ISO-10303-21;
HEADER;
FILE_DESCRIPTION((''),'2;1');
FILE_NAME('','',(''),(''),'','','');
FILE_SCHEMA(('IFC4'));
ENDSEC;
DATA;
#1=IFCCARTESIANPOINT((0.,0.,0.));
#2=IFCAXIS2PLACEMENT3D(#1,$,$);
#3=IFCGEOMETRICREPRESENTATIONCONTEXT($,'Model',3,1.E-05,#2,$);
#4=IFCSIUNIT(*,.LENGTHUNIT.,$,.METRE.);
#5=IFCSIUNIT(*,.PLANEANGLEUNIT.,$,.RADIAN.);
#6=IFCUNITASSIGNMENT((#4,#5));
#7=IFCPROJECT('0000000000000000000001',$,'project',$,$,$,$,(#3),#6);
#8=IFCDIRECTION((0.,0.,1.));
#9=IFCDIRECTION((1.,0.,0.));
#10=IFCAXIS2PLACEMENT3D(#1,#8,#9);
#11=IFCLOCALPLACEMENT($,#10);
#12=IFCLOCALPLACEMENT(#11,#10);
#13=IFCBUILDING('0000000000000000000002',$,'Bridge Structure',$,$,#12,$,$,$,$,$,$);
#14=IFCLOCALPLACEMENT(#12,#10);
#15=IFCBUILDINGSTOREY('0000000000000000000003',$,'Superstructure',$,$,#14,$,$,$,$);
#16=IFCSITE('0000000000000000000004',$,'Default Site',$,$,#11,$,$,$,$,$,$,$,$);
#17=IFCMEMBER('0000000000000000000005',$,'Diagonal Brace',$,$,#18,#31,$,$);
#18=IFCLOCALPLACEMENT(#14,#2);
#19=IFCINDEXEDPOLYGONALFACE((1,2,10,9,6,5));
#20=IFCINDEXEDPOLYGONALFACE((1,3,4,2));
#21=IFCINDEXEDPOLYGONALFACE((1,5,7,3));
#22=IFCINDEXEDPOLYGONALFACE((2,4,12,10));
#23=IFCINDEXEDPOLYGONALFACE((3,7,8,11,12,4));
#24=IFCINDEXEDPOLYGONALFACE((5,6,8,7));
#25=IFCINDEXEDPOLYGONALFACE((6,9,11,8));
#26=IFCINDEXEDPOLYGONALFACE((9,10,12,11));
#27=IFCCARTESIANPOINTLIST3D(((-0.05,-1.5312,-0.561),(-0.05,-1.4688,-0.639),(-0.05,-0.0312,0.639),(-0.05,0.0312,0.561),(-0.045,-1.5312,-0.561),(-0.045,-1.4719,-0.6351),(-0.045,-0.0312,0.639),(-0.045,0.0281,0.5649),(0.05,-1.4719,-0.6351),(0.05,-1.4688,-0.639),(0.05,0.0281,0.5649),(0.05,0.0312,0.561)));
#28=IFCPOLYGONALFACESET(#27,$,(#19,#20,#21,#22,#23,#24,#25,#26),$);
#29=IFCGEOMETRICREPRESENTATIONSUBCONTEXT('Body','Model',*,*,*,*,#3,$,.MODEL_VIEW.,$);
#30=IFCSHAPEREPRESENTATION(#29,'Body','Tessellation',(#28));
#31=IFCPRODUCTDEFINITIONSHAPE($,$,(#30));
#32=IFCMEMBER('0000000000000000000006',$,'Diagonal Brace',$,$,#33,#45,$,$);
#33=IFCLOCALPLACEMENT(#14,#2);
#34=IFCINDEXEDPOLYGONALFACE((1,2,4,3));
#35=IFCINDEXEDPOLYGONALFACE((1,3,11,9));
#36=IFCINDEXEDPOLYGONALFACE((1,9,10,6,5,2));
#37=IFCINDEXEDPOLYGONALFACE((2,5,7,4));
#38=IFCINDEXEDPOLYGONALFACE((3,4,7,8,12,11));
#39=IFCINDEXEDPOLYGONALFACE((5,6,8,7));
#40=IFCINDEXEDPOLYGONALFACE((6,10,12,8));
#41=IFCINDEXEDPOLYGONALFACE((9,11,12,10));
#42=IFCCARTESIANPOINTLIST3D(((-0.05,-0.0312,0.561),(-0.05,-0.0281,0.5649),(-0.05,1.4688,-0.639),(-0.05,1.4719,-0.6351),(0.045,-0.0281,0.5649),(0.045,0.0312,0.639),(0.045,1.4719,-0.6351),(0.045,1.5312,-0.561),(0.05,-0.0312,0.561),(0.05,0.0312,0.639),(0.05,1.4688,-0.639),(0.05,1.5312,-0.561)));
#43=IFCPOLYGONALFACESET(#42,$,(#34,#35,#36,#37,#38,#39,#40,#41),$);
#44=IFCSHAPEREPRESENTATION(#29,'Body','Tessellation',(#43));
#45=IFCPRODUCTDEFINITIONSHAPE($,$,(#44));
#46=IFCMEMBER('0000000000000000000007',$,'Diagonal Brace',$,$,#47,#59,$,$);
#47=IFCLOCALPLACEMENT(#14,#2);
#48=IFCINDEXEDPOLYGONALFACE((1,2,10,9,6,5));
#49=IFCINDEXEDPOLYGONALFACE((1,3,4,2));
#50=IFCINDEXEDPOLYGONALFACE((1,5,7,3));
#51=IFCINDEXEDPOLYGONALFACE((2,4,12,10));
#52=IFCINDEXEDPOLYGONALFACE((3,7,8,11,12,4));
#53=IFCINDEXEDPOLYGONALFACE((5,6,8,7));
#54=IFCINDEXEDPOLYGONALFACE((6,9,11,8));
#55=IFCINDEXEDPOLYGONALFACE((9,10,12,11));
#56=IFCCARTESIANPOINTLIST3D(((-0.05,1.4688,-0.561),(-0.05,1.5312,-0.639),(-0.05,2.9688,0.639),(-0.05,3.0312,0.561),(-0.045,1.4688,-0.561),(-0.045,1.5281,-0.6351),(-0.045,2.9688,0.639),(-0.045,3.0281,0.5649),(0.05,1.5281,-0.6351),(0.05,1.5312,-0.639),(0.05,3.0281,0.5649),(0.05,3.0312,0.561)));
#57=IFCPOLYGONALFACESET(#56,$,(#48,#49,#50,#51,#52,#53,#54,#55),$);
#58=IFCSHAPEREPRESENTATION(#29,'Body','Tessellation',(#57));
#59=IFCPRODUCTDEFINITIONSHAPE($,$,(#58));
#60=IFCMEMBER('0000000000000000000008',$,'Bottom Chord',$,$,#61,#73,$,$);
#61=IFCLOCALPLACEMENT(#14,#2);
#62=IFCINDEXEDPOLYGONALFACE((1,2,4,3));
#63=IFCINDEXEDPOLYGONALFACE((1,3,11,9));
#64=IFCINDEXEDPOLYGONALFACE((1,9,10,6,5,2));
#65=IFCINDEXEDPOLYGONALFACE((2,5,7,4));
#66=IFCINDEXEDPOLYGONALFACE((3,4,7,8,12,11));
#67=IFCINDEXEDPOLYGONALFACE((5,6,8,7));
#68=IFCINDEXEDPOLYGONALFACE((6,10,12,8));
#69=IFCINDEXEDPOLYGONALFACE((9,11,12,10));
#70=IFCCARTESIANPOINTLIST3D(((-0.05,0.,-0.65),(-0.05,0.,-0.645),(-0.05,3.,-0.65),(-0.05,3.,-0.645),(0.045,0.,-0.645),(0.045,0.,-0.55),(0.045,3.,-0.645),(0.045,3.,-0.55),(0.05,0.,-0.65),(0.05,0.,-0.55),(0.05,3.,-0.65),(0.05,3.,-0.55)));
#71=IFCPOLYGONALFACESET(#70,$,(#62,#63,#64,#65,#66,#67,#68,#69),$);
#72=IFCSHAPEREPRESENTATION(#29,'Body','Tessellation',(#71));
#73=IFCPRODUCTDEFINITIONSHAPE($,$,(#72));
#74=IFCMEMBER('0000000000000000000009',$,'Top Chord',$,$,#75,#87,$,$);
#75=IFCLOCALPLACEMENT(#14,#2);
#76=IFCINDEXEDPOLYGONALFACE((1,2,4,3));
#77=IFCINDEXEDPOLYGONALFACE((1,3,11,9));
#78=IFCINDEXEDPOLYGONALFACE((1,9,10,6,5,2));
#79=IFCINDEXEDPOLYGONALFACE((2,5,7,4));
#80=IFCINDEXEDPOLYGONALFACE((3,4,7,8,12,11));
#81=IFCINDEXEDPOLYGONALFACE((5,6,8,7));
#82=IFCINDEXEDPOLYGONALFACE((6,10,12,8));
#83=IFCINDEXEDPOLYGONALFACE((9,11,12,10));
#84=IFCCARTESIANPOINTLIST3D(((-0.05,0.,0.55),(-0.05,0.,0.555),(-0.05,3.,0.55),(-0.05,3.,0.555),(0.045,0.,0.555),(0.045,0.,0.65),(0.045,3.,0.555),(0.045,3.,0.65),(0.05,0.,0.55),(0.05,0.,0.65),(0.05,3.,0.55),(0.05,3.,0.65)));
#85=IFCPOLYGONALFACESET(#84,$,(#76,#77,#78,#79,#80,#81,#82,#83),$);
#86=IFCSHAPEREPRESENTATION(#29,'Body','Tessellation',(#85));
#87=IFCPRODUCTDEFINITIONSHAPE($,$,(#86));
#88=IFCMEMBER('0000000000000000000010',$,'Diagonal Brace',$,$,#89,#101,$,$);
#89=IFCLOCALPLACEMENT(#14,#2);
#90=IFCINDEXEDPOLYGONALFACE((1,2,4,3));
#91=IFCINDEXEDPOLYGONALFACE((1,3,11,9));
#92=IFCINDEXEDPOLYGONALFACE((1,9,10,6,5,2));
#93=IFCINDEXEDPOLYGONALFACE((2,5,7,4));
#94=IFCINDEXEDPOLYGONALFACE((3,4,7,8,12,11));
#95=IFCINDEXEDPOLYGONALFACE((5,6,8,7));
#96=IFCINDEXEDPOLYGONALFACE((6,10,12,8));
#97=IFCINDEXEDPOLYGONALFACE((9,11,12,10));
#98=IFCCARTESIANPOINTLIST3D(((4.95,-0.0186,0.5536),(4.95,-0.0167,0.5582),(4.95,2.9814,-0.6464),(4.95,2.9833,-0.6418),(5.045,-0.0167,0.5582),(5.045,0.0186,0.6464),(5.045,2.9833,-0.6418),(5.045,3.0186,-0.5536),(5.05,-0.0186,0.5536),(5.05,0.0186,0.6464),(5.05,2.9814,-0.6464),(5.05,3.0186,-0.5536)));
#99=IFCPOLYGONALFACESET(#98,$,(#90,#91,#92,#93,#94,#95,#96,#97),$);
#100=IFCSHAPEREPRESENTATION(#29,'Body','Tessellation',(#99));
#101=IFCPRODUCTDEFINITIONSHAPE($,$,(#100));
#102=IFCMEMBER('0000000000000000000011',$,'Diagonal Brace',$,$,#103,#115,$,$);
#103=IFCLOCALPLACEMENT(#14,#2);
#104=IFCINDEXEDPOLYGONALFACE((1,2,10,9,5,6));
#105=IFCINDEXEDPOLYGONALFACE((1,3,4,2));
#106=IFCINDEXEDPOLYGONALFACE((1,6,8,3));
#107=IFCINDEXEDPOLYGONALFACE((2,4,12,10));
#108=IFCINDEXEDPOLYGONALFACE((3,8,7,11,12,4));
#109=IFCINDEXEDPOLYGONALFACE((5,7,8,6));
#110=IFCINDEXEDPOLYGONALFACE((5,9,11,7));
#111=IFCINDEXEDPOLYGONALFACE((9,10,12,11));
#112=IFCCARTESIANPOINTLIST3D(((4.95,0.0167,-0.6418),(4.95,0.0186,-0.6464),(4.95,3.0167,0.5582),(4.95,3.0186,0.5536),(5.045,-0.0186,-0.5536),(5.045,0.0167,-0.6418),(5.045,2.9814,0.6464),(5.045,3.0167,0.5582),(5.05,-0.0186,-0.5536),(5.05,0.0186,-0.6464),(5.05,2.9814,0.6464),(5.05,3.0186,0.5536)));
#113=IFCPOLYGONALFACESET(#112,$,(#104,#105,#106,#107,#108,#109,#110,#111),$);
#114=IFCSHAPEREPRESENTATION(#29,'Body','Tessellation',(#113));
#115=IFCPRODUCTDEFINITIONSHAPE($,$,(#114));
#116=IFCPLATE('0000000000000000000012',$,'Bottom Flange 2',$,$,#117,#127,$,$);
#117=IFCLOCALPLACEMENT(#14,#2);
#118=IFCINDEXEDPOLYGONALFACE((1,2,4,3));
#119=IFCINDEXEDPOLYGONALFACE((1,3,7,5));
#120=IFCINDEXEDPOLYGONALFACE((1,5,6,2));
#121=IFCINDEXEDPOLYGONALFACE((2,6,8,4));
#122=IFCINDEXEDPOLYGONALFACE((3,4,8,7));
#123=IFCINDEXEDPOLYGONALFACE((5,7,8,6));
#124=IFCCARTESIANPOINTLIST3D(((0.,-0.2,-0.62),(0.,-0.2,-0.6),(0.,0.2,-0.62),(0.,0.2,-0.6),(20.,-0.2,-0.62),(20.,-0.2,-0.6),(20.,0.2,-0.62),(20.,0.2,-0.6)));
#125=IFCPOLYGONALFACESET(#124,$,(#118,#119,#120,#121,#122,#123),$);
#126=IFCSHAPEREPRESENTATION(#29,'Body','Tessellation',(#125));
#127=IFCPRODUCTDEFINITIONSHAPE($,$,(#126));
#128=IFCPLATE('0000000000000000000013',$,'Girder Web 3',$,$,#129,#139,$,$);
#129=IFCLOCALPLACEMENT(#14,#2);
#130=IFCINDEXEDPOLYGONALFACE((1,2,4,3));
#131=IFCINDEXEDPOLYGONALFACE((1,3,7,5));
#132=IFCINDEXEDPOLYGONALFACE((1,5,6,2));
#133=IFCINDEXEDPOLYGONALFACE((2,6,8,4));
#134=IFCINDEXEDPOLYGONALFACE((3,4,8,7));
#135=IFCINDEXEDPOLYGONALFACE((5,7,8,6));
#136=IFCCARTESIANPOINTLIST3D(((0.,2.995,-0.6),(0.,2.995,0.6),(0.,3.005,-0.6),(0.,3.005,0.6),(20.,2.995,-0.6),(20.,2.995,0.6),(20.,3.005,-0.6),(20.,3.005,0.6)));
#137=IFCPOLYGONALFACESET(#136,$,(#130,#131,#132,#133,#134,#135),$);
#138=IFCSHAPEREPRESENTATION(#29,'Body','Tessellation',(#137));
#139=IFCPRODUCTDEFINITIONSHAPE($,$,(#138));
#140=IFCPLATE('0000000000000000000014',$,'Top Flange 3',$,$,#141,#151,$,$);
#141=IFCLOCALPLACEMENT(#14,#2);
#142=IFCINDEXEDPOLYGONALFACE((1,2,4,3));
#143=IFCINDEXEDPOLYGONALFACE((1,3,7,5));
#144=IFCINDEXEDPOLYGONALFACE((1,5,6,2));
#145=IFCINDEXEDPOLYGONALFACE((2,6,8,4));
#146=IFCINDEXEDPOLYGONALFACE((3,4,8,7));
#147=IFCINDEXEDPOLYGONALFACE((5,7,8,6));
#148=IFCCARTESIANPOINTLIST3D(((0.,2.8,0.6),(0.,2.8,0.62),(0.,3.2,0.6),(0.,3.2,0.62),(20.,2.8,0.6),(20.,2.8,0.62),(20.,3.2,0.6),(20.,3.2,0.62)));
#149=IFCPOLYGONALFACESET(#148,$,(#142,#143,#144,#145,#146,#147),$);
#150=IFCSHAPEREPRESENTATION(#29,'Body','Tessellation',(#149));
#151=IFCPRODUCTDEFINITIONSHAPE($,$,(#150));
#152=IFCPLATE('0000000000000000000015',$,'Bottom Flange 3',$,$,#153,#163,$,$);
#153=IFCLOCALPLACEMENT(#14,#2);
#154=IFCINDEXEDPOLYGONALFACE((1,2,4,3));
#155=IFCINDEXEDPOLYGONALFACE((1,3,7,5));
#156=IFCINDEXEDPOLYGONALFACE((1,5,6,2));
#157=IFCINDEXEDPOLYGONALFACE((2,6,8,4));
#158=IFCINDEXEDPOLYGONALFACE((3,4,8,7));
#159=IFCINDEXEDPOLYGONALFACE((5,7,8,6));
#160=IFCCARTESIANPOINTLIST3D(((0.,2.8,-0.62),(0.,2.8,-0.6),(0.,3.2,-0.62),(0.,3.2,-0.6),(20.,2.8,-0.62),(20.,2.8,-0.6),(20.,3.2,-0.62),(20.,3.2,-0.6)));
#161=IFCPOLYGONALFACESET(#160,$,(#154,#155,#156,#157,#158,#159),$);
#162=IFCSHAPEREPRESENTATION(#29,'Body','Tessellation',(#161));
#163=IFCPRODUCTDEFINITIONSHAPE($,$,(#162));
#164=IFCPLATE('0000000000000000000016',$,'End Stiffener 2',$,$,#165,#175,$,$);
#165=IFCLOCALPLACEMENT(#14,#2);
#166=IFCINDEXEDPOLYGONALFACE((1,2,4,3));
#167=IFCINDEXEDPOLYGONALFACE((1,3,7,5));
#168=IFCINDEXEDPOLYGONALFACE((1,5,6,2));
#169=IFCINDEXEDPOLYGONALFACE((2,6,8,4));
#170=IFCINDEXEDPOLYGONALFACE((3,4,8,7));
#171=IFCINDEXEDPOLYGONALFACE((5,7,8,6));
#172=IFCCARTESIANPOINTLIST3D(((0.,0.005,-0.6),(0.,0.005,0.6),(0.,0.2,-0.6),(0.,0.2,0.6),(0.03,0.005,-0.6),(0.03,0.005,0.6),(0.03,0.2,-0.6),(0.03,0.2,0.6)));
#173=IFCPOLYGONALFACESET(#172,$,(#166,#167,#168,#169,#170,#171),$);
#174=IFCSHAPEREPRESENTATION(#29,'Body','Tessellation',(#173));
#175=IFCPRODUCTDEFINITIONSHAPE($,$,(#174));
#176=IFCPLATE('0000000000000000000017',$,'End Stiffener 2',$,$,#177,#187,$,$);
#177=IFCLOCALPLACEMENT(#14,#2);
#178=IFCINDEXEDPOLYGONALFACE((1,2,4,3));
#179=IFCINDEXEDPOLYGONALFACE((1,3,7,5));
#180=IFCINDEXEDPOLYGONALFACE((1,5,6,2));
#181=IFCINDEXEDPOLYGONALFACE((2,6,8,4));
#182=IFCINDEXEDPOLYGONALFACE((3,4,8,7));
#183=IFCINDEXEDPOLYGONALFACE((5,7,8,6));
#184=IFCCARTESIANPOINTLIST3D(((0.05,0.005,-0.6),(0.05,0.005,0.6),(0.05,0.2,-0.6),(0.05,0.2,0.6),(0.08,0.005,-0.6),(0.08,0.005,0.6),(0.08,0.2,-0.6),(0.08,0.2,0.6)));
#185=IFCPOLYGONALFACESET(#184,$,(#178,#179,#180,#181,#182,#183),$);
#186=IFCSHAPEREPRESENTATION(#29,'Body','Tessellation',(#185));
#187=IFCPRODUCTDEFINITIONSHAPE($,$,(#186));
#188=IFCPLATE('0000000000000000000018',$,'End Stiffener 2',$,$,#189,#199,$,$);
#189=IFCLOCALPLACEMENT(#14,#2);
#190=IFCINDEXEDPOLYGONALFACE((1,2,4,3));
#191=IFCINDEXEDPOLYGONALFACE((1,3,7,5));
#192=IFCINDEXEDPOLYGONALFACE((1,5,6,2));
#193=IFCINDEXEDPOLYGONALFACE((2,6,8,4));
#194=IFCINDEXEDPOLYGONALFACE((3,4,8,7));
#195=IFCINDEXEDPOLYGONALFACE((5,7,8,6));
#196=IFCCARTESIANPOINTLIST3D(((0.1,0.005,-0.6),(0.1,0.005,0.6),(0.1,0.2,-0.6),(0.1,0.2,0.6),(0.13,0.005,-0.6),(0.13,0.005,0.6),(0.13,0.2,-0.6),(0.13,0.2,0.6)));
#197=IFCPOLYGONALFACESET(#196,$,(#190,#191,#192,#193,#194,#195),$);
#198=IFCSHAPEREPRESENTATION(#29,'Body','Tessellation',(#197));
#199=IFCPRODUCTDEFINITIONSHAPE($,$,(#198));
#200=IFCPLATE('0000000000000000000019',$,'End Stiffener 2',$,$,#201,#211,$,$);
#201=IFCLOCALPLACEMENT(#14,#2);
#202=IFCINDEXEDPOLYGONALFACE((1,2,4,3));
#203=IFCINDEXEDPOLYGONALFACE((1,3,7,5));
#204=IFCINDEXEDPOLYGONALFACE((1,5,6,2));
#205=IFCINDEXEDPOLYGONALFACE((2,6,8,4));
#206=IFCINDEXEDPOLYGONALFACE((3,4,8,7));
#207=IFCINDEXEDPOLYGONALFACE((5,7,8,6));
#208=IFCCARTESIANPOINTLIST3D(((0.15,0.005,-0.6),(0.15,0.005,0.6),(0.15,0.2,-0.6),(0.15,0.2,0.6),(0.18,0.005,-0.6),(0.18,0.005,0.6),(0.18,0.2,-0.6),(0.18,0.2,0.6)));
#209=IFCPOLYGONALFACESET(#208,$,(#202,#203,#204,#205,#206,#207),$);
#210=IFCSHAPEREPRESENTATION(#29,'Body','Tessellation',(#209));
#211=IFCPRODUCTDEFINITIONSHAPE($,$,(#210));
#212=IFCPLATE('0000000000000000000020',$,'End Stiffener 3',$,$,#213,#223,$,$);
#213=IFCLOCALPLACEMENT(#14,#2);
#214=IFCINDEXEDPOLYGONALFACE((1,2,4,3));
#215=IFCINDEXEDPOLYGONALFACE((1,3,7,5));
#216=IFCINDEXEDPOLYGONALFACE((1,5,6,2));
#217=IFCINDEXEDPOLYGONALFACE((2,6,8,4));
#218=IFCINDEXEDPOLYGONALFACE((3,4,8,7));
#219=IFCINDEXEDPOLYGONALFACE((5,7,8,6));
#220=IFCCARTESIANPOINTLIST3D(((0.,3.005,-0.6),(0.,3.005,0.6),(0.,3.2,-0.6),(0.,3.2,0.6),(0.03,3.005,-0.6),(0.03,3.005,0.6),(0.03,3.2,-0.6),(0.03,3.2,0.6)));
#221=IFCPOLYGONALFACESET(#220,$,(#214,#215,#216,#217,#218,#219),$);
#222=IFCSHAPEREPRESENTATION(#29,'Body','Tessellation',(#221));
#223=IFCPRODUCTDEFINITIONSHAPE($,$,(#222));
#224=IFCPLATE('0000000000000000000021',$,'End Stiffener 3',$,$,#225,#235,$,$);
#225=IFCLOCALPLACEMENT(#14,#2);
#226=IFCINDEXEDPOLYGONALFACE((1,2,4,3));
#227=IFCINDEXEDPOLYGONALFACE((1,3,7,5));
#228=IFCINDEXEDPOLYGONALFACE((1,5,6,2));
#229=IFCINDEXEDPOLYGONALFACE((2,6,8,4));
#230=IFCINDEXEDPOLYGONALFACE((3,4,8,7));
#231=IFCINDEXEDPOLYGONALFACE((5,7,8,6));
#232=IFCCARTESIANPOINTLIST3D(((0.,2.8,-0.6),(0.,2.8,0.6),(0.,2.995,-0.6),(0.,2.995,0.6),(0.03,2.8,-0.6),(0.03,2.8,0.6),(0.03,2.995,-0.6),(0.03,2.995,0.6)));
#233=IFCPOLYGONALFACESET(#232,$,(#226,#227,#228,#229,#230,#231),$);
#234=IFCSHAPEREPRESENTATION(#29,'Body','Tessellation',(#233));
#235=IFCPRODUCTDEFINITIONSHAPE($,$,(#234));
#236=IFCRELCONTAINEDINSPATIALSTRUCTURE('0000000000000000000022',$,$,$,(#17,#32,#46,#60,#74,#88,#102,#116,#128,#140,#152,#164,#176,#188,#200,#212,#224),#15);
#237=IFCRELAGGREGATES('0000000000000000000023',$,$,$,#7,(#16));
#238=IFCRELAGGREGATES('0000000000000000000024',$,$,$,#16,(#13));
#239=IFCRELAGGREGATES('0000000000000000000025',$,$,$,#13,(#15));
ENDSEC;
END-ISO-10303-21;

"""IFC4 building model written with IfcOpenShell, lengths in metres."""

from ifc_helpers import new_model, si_unit, frame, origin, origin_with_axes, origin_2d_with_axis, place, context, subcontext, project, spatial, rectangle, l_section, extrude, element, save


model = new_model("IFC4")

# Units and contexts
model_context = context("Model", 3, precision=1e-05, world=origin())
body_context = subcontext(model_context, "Body", "Model", "MODEL_VIEW")
ifc_project = project(units=[si_unit("LENGTHUNIT", "METRE"), si_unit("PLANEANGLEUNIT", "RADIAN")], contexts=[model_context])

# Site, building, storey
site_placement = place(None, origin_with_axes())
site = spatial("IfcSite", under=ifc_project, at=site_placement, Name="Default Site")
building_placement = place(site_placement, origin_with_axes())
building = spatial("IfcBuilding", under=site, at=building_placement, Name="Bridge Structure")
storey_placement = place(building_placement, origin_with_axes())
storey = spatial("IfcBuildingStorey", under=building, at=storey_placement, Name="Superstructure")

# Members
for number, where, z_axis, x_axis, name in (
    (1, (0.0, 0.0, 0.6), (0.0, -0.780869, -0.624695), (1.0, 0.0, 0.0), "Diagonal Brace"),
    (2, (0.0, 0.0, 0.6), (0.0, 0.780869, -0.624695), (-1.0, 0.0, 0.0), "Diagonal Brace"),
    (3, (0.0, 3.0, 0.6), (0.0, -0.780869, -0.624695), (1.0, 0.0, 0.0), "Diagonal Brace"),
):
    element("IfcMember", number, at=place(storey_placement, frame(where, z_axis=z_axis, x_axis=x_axis)), inside=storey, Name=name, context=body_context, shape_type="SweptSolid", body=[
        extrude(l_section(Depth=0.1, Width=0.1, Thickness=0.005, at=origin_2d_with_axis()), origin_with_axes(), (0.0, 0.0, 1.0), 1.9209),
    ])
for number, where, z_axis, x_axis, name in (
    (4, (0.0, 0.0, -0.6), (0.0, 1.0, 0.0), (-1.0, 0.0, 0.0), "Bottom Chord"),
    (5, (0.0, 0.0, 0.6), (0.0, 1.0, 0.0), (-1.0, 0.0, 0.0), "Top Chord"),
):
    element("IfcMember", number, at=place(storey_placement, frame(where, z_axis=z_axis, x_axis=x_axis)), inside=storey, Name=name, context=body_context, shape_type="SweptSolid", body=[
        extrude(l_section(Depth=0.1, Width=0.1, Thickness=0.005, at=origin_2d_with_axis()), origin_with_axes(), (0.0, 0.0, 1.0), 3.0),
    ])
for number, where, z_axis, x_axis, name in (
    (6, (5.0, 0.0, 0.6), (0.0, 0.928477, -0.371391), (-1.0, 0.0, 0.0), "Diagonal Brace"),
    (7, (5.0, 0.0, -0.6), (0.0, 0.928477, 0.371391), (-1.0, 0.0, 0.0), "Diagonal Brace"),
):
    element("IfcMember", number, at=place(storey_placement, frame(where, z_axis=z_axis, x_axis=x_axis)), inside=storey, Name=name, context=body_context, shape_type="SweptSolid", body=[
        extrude(l_section(Depth=0.1, Width=0.1, Thickness=0.005, at=origin_2d_with_axis()), origin_with_axes(), (0.0, 0.0, 1.0), 3.2311),
    ])

# Plates
plate_1_placement = place(storey_placement, frame((0.0, 0.0, -0.61), z_axis=(1.0, 0.0, 0.0), x_axis=(0.0, 1.0, 0.0)))
element("IfcPlate", 8, at=plate_1_placement, inside=storey, Name="Bottom Flange 2", context=body_context, shape_type="SweptSolid", body=[
    extrude(rectangle(XDim=0.4, YDim=0.02, at=origin_2d_with_axis()), origin_with_axes(), (0.0, 0.0, 1.0), 20.0),
])
plate_2_placement = place(storey_placement, frame((0.0, 3.0, 0.0), z_axis=(1.0, 0.0, 0.0), x_axis=(0.0, 1.0, 0.0)))
element("IfcPlate", 9, at=plate_2_placement, inside=storey, Name="Girder Web 3", context=body_context, shape_type="SweptSolid", body=[
    extrude(rectangle(XDim=0.01, YDim=1.2, at=origin_2d_with_axis()), origin_with_axes(), (0.0, 0.0, 1.0), 20.0),
])
for number, where, z_axis, x_axis, name in (
    (10, (0.0, 3.0, 0.61), (1.0, 0.0, 0.0), (0.0, 1.0, 0.0), "Top Flange 3"),
    (11, (0.0, 3.0, -0.61), (1.0, 0.0, 0.0), (0.0, 1.0, 0.0), "Bottom Flange 3"),
):
    element("IfcPlate", number, at=place(storey_placement, frame(where, z_axis=z_axis, x_axis=x_axis)), inside=storey, Name=name, context=body_context, shape_type="SweptSolid", body=[
        extrude(rectangle(XDim=0.4, YDim=0.02, at=origin_2d_with_axis()), origin_with_axes(), (0.0, 0.0, 1.0), 20.0),
    ])
for number, where, z_axis, x_axis, name in (
    (12, (0.015, 0.1025, -0.6), (0.0, 0.0, 1.0), (1.0, 0.0, 0.0), "End Stiffener 2"),
    (13, (0.065, 0.1025, -0.6), (0.0, 0.0, 1.0), (1.0, 0.0, 0.0), "End Stiffener 2"),
    (14, (0.115, 0.1025, -0.6), (0.0, 0.0, 1.0), (1.0, 0.0, 0.0), "End Stiffener 2"),
    (15, (0.165, 0.1025, -0.6), (0.0, 0.0, 1.0), (1.0, 0.0, 0.0), "End Stiffener 2"),
    (16, (0.015, 3.1025, -0.6), (0.0, 0.0, 1.0), (1.0, 0.0, 0.0), "End Stiffener 3"),
    (17, (0.015, 2.8975, -0.6), (0.0, 0.0, 1.0), (1.0, 0.0, 0.0), "End Stiffener 3"),
):
    element("IfcPlate", number, at=place(storey_placement, frame(where, z_axis=z_axis, x_axis=x_axis)), inside=storey, Name=name, context=body_context, shape_type="SweptSolid", body=[
        extrude(rectangle(XDim=0.03, YDim=0.195, at=origin_2d_with_axis()), origin_with_axes(), (0.0, 0.0, 1.0), 1.2),
    ])

save(model, "model.ifc")
